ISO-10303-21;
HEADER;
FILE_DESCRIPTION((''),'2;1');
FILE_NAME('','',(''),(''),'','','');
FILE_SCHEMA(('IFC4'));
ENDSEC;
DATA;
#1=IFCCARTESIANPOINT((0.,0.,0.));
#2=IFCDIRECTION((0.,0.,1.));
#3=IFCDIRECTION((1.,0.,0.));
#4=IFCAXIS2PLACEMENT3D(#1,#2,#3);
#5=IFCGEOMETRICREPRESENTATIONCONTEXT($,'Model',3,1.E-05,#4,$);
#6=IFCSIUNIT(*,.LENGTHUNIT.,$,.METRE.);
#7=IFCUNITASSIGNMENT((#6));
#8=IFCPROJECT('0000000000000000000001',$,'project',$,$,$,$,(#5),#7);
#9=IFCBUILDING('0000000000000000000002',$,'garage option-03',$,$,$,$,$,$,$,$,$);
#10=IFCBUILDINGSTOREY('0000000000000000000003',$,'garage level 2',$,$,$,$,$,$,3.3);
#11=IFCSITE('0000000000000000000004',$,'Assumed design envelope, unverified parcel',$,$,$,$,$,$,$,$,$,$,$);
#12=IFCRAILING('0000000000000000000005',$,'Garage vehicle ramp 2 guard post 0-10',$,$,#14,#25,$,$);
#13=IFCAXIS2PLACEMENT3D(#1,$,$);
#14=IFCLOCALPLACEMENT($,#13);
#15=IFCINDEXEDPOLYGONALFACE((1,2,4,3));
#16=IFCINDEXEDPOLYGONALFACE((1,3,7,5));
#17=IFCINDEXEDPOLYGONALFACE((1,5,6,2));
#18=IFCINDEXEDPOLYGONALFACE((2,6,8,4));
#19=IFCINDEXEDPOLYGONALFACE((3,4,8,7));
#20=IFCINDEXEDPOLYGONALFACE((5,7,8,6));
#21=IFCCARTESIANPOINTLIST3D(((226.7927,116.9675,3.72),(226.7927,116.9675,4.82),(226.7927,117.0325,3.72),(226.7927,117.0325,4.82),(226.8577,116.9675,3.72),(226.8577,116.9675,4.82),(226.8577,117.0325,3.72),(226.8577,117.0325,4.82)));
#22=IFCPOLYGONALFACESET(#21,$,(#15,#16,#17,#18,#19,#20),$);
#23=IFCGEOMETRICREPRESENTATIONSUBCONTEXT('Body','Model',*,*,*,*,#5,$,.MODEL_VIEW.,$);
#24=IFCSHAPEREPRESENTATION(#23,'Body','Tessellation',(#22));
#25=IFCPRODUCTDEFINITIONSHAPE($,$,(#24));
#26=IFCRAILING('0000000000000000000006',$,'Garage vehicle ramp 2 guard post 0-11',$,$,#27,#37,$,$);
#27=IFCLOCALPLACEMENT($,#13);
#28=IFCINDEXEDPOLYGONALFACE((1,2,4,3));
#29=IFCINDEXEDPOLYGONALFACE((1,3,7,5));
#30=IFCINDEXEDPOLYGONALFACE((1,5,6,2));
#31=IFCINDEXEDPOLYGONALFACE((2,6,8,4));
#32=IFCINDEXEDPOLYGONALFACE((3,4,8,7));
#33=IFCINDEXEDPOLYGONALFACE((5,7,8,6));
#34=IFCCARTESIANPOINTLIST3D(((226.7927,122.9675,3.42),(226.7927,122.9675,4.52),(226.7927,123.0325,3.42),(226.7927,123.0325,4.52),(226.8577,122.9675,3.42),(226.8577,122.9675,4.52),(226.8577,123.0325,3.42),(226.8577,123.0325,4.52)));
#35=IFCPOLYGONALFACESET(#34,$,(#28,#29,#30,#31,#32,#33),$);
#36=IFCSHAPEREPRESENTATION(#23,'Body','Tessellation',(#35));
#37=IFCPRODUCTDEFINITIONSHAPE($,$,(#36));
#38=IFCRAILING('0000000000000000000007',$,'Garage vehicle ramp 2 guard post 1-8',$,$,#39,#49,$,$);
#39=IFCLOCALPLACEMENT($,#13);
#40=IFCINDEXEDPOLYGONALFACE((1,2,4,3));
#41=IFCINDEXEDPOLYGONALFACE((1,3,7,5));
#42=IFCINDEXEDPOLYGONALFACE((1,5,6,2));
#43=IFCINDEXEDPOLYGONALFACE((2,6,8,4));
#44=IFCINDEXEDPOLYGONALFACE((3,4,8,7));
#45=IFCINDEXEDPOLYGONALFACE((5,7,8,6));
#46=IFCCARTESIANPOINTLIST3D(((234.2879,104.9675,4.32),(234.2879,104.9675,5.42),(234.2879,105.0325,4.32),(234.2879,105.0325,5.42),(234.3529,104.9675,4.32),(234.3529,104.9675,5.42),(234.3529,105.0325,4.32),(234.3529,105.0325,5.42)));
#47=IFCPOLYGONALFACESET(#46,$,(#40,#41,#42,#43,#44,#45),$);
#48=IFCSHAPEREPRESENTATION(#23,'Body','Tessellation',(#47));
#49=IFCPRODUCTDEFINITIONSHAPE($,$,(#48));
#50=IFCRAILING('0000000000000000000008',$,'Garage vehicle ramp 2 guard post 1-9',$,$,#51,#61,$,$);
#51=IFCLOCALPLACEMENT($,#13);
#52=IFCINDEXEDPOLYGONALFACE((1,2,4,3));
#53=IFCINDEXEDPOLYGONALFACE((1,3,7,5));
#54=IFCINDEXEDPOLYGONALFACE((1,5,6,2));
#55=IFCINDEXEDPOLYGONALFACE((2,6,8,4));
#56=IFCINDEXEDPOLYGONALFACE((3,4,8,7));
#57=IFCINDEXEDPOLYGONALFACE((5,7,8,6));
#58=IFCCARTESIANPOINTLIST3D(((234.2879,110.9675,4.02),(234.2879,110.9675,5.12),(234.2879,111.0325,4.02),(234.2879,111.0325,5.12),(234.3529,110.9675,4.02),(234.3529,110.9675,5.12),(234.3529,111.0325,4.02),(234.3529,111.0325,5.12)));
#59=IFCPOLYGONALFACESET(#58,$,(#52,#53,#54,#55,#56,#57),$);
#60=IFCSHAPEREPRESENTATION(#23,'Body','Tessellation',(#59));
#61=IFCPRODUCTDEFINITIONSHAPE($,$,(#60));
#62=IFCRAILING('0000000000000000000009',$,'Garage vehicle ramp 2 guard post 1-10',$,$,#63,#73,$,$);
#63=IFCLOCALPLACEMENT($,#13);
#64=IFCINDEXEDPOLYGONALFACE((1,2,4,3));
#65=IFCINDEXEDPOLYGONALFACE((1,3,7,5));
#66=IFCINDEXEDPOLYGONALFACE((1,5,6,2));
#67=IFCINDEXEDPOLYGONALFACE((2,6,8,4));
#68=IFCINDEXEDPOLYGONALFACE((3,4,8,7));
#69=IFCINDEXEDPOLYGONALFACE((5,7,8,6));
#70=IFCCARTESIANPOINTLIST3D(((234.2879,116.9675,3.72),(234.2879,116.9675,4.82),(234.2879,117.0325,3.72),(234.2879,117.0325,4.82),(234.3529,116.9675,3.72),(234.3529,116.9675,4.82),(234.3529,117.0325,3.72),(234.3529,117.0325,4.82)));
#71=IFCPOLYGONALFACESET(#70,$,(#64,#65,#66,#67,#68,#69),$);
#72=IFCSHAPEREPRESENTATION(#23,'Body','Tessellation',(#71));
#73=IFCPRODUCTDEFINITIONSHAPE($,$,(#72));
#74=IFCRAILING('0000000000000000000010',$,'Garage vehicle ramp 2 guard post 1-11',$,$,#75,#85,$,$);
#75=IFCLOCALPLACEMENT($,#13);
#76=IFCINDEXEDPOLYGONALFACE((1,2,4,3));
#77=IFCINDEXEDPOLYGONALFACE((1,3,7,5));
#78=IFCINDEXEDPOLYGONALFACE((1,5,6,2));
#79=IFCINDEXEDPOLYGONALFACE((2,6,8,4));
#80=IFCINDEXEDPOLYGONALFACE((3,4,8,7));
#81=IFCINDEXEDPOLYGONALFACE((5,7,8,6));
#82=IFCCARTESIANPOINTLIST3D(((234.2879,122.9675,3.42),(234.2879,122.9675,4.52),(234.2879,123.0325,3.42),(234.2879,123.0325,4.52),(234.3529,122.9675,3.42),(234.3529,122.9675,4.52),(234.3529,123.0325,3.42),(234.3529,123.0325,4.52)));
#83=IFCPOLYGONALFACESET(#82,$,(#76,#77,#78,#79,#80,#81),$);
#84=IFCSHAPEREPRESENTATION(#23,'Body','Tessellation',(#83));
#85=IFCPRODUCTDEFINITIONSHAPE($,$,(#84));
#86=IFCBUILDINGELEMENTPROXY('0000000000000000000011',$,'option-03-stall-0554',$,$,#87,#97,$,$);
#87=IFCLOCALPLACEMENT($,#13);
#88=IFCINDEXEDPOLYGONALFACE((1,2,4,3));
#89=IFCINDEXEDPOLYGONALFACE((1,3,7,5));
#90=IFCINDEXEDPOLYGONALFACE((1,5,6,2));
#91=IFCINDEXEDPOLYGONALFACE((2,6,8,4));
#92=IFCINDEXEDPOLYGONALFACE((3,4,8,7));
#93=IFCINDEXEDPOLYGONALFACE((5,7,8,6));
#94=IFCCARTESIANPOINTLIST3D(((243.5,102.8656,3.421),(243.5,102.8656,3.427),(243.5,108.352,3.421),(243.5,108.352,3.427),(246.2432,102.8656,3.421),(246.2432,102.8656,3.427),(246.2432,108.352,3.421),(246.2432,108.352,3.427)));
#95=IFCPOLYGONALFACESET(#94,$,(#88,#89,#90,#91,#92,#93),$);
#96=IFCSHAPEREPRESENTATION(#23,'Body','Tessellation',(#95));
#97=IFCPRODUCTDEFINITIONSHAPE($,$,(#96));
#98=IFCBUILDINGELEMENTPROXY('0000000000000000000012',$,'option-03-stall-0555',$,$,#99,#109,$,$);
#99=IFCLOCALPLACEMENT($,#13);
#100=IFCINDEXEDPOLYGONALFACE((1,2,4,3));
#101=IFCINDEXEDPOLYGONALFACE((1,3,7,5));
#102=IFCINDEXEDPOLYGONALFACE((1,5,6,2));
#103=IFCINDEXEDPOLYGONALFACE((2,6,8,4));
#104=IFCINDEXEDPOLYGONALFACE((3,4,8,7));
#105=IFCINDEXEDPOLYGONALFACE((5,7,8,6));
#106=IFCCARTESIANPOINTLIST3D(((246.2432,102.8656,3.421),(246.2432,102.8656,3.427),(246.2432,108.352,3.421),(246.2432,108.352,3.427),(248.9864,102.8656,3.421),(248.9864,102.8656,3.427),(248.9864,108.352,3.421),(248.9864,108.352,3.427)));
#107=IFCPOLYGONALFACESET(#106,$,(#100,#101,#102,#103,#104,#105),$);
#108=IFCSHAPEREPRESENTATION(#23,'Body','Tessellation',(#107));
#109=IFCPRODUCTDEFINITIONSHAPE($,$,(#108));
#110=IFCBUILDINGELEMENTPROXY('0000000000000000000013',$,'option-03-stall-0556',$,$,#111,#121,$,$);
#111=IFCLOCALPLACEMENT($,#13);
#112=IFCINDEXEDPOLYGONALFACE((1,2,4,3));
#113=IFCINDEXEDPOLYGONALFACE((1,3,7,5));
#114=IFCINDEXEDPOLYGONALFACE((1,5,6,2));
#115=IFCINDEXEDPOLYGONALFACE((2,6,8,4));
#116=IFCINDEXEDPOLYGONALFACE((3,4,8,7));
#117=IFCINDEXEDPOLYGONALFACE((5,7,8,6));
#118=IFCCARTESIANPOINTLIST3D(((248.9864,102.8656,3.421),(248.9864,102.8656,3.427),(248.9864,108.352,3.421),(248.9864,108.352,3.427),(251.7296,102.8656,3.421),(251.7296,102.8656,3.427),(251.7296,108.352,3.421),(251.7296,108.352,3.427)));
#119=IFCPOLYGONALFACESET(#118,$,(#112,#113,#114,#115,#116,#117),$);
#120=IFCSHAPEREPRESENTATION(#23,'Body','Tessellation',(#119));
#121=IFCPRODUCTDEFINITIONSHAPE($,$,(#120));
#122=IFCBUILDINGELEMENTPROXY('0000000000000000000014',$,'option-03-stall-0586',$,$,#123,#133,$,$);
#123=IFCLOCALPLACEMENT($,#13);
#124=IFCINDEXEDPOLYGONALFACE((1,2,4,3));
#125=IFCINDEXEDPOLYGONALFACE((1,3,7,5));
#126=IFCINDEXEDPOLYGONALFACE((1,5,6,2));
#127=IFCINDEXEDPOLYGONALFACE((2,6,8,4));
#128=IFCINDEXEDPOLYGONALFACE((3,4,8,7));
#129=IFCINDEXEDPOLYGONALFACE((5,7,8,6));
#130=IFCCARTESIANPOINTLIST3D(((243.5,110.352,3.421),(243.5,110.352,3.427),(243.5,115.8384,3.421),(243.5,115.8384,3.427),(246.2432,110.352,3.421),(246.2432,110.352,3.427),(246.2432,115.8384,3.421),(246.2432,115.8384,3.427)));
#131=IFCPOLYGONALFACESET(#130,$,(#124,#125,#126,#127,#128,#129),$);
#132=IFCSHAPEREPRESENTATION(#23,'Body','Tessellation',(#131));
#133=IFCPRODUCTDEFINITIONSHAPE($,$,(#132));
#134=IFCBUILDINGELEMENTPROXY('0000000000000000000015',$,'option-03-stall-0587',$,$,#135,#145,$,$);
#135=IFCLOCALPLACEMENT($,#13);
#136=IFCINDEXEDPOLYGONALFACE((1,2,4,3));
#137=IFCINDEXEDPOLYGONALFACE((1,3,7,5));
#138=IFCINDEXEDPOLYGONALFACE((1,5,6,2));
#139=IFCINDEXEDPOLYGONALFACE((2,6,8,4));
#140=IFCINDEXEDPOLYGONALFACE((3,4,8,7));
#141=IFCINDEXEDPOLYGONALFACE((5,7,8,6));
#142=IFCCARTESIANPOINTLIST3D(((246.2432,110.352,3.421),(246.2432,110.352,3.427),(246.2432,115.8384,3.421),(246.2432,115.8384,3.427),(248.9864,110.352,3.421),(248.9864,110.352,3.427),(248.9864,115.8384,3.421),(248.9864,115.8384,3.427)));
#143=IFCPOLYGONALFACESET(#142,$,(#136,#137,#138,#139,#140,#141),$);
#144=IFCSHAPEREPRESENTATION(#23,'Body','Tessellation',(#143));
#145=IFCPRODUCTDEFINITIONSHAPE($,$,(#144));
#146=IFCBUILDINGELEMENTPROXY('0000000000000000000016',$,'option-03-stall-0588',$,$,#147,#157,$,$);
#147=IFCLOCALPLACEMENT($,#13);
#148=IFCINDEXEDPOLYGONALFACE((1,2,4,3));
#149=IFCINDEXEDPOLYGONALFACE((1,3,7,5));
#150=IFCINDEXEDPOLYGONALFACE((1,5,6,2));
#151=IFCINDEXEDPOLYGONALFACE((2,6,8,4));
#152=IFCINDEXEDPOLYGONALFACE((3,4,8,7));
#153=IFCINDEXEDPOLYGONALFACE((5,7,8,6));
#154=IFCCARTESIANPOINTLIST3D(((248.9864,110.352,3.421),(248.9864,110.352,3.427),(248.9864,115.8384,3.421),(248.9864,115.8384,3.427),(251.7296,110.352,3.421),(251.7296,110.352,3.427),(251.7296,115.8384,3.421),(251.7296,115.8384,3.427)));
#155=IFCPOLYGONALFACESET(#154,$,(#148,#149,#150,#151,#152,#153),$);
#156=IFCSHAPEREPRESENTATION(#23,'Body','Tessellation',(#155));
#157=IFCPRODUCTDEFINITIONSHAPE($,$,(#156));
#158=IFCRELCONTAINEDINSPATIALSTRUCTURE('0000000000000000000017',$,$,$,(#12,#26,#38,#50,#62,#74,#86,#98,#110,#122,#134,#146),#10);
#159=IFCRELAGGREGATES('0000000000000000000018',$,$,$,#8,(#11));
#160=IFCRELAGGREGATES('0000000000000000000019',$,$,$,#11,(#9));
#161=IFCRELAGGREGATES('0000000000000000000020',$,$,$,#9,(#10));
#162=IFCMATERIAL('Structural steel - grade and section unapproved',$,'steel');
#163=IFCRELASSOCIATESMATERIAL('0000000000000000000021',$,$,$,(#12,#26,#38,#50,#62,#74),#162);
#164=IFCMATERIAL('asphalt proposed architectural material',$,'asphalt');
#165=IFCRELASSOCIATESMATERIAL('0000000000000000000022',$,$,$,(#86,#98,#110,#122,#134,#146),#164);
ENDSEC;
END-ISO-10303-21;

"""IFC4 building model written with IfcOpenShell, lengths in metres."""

from ifc_helpers import new_model, si_unit, frame, origin_with_axes, place, context, subcontext, project, spatial, rectangle, extrude, material, element, save


model = new_model("IFC4")

# Units and contexts
model_context = context("Model", 3, precision=1e-05, world=origin_with_axes())
body_context = subcontext(model_context, "Body", "Model", "MODEL_VIEW")
ifc_project = project(units=[si_unit("LENGTHUNIT", "METRE")], contexts=[model_context])

# Site, building, storey
site = spatial("IfcSite", under=ifc_project, Name="Assumed design envelope, unverified parcel")
building = spatial("IfcBuilding", under=site, Name="garage option-03")
storey = spatial("IfcBuildingStorey", under=building, Name="garage level 2", Elevation=3.3)

# Shared definitions
ifc_material_1 = material(Name="Structural steel - grade and section unapproved", Category="steel")

# Railings
railing_1_placement = place(None, frame((226.8252, 117.0, 3.72), z_axis=(0.0, 0.0, 1.0), x_axis=(-1.0, 0.0, 0.0)))
element("IfcRailing", 1, at=railing_1_placement, inside=storey, material=ifc_material_1, Name="Garage vehicle ramp 2 guard post 0-10", context=body_context, shape_type="SweptSolid", body=[
    extrude(rectangle(XDim=0.065, YDim=0.065), origin_with_axes(), (0.0, 0.0, 1.0), 1.1),
])
for number, where, z_axis, x_axis, name in (
    (2, (226.8252, 123.0, 3.42), (0.0, 0.0, 1.0), (-1.0, 0.0, 0.0), "Garage vehicle ramp 2 guard post 0-11"),
    (3, (234.3204, 105.0, 4.32), (0.0, 0.0, 1.0), (-1.0, 0.0, 0.0), "Garage vehicle ramp 2 guard post 1-8"),
    (4, (234.3204, 111.0, 4.02), (0.0, 0.0, 1.0), (-1.0, 0.0, 0.0), "Garage vehicle ramp 2 guard post 1-9"),
):
    element("IfcRailing", number, at=place(None, frame(where, z_axis=z_axis, x_axis=x_axis)), inside=storey, material=ifc_material_1, Name=name, context=body_context, shape_type="SweptSolid", body=[
        extrude(rectangle(XDim=0.065, YDim=0.065), origin_with_axes(), (0.0, 0.0, 1.0), 1.1),
    ])
railing_2_placement = place(None, frame((234.3204, 117.0, 3.72), z_axis=(0.0, 0.0, 1.0), x_axis=(-1.0, 0.0, 0.0)))
element("IfcRailing", 5, at=railing_2_placement, inside=storey, material=ifc_material_1, Name="Garage vehicle ramp 2 guard post 1-10", context=body_context, shape_type="SweptSolid", body=[
    extrude(rectangle(XDim=0.065, YDim=0.065), origin_with_axes(), (0.0, 0.0, 1.0), 1.1),
])
railing_3_placement = place(None, frame((234.3204, 123.0, 3.42), z_axis=(0.0, 0.0, 1.0), x_axis=(-1.0, 0.0, 0.0)))
element("IfcRailing", 6, at=railing_3_placement, inside=storey, material=ifc_material_1, Name="Garage vehicle ramp 2 guard post 1-11", context=body_context, shape_type="SweptSolid", body=[
    extrude(rectangle(XDim=0.065, YDim=0.065), origin_with_axes(), (0.0, 0.0, 1.0), 1.1),
])

# Building element proxies
ifc_material_2 = material(Name="asphalt proposed architectural material", Category="asphalt")
for number, where, z_axis, x_axis, name in (
    (7, (244.8716, 105.6088, 3.421), (0.0, 0.0, 1.0), (1.0, 0.0, 0.0), "option-03-stall-0554"),
    (8, (247.6148, 105.6088, 3.421), (0.0, 0.0, 1.0), (1.0, 0.0, 0.0), "option-03-stall-0555"),
    (9, (250.358, 105.6088, 3.421), (0.0, 0.0, 1.0), (1.0, 0.0, 0.0), "option-03-stall-0556"),
    (10, (244.8716, 113.0952, 3.421), (0.0, 0.0, 1.0), (1.0, 0.0, 0.0), "option-03-stall-0586"),
    (11, (247.6148, 113.0952, 3.421), (0.0, 0.0, 1.0), (1.0, 0.0, 0.0), "option-03-stall-0587"),
    (12, (250.358, 113.0952, 3.421), (0.0, 0.0, 1.0), (1.0, 0.0, 0.0), "option-03-stall-0588"),
):
    element("IfcBuildingElementProxy", number, at=place(None, frame(where, z_axis=z_axis, x_axis=x_axis)), inside=storey, material=ifc_material_2, Name=name, context=body_context, shape_type="SweptSolid", body=[
        extrude(rectangle(XDim=2.7432, YDim=5.4864), origin_with_axes(), (0.0, 0.0, 1.0), 0.006),
    ])

save(model, "model.ifc")
